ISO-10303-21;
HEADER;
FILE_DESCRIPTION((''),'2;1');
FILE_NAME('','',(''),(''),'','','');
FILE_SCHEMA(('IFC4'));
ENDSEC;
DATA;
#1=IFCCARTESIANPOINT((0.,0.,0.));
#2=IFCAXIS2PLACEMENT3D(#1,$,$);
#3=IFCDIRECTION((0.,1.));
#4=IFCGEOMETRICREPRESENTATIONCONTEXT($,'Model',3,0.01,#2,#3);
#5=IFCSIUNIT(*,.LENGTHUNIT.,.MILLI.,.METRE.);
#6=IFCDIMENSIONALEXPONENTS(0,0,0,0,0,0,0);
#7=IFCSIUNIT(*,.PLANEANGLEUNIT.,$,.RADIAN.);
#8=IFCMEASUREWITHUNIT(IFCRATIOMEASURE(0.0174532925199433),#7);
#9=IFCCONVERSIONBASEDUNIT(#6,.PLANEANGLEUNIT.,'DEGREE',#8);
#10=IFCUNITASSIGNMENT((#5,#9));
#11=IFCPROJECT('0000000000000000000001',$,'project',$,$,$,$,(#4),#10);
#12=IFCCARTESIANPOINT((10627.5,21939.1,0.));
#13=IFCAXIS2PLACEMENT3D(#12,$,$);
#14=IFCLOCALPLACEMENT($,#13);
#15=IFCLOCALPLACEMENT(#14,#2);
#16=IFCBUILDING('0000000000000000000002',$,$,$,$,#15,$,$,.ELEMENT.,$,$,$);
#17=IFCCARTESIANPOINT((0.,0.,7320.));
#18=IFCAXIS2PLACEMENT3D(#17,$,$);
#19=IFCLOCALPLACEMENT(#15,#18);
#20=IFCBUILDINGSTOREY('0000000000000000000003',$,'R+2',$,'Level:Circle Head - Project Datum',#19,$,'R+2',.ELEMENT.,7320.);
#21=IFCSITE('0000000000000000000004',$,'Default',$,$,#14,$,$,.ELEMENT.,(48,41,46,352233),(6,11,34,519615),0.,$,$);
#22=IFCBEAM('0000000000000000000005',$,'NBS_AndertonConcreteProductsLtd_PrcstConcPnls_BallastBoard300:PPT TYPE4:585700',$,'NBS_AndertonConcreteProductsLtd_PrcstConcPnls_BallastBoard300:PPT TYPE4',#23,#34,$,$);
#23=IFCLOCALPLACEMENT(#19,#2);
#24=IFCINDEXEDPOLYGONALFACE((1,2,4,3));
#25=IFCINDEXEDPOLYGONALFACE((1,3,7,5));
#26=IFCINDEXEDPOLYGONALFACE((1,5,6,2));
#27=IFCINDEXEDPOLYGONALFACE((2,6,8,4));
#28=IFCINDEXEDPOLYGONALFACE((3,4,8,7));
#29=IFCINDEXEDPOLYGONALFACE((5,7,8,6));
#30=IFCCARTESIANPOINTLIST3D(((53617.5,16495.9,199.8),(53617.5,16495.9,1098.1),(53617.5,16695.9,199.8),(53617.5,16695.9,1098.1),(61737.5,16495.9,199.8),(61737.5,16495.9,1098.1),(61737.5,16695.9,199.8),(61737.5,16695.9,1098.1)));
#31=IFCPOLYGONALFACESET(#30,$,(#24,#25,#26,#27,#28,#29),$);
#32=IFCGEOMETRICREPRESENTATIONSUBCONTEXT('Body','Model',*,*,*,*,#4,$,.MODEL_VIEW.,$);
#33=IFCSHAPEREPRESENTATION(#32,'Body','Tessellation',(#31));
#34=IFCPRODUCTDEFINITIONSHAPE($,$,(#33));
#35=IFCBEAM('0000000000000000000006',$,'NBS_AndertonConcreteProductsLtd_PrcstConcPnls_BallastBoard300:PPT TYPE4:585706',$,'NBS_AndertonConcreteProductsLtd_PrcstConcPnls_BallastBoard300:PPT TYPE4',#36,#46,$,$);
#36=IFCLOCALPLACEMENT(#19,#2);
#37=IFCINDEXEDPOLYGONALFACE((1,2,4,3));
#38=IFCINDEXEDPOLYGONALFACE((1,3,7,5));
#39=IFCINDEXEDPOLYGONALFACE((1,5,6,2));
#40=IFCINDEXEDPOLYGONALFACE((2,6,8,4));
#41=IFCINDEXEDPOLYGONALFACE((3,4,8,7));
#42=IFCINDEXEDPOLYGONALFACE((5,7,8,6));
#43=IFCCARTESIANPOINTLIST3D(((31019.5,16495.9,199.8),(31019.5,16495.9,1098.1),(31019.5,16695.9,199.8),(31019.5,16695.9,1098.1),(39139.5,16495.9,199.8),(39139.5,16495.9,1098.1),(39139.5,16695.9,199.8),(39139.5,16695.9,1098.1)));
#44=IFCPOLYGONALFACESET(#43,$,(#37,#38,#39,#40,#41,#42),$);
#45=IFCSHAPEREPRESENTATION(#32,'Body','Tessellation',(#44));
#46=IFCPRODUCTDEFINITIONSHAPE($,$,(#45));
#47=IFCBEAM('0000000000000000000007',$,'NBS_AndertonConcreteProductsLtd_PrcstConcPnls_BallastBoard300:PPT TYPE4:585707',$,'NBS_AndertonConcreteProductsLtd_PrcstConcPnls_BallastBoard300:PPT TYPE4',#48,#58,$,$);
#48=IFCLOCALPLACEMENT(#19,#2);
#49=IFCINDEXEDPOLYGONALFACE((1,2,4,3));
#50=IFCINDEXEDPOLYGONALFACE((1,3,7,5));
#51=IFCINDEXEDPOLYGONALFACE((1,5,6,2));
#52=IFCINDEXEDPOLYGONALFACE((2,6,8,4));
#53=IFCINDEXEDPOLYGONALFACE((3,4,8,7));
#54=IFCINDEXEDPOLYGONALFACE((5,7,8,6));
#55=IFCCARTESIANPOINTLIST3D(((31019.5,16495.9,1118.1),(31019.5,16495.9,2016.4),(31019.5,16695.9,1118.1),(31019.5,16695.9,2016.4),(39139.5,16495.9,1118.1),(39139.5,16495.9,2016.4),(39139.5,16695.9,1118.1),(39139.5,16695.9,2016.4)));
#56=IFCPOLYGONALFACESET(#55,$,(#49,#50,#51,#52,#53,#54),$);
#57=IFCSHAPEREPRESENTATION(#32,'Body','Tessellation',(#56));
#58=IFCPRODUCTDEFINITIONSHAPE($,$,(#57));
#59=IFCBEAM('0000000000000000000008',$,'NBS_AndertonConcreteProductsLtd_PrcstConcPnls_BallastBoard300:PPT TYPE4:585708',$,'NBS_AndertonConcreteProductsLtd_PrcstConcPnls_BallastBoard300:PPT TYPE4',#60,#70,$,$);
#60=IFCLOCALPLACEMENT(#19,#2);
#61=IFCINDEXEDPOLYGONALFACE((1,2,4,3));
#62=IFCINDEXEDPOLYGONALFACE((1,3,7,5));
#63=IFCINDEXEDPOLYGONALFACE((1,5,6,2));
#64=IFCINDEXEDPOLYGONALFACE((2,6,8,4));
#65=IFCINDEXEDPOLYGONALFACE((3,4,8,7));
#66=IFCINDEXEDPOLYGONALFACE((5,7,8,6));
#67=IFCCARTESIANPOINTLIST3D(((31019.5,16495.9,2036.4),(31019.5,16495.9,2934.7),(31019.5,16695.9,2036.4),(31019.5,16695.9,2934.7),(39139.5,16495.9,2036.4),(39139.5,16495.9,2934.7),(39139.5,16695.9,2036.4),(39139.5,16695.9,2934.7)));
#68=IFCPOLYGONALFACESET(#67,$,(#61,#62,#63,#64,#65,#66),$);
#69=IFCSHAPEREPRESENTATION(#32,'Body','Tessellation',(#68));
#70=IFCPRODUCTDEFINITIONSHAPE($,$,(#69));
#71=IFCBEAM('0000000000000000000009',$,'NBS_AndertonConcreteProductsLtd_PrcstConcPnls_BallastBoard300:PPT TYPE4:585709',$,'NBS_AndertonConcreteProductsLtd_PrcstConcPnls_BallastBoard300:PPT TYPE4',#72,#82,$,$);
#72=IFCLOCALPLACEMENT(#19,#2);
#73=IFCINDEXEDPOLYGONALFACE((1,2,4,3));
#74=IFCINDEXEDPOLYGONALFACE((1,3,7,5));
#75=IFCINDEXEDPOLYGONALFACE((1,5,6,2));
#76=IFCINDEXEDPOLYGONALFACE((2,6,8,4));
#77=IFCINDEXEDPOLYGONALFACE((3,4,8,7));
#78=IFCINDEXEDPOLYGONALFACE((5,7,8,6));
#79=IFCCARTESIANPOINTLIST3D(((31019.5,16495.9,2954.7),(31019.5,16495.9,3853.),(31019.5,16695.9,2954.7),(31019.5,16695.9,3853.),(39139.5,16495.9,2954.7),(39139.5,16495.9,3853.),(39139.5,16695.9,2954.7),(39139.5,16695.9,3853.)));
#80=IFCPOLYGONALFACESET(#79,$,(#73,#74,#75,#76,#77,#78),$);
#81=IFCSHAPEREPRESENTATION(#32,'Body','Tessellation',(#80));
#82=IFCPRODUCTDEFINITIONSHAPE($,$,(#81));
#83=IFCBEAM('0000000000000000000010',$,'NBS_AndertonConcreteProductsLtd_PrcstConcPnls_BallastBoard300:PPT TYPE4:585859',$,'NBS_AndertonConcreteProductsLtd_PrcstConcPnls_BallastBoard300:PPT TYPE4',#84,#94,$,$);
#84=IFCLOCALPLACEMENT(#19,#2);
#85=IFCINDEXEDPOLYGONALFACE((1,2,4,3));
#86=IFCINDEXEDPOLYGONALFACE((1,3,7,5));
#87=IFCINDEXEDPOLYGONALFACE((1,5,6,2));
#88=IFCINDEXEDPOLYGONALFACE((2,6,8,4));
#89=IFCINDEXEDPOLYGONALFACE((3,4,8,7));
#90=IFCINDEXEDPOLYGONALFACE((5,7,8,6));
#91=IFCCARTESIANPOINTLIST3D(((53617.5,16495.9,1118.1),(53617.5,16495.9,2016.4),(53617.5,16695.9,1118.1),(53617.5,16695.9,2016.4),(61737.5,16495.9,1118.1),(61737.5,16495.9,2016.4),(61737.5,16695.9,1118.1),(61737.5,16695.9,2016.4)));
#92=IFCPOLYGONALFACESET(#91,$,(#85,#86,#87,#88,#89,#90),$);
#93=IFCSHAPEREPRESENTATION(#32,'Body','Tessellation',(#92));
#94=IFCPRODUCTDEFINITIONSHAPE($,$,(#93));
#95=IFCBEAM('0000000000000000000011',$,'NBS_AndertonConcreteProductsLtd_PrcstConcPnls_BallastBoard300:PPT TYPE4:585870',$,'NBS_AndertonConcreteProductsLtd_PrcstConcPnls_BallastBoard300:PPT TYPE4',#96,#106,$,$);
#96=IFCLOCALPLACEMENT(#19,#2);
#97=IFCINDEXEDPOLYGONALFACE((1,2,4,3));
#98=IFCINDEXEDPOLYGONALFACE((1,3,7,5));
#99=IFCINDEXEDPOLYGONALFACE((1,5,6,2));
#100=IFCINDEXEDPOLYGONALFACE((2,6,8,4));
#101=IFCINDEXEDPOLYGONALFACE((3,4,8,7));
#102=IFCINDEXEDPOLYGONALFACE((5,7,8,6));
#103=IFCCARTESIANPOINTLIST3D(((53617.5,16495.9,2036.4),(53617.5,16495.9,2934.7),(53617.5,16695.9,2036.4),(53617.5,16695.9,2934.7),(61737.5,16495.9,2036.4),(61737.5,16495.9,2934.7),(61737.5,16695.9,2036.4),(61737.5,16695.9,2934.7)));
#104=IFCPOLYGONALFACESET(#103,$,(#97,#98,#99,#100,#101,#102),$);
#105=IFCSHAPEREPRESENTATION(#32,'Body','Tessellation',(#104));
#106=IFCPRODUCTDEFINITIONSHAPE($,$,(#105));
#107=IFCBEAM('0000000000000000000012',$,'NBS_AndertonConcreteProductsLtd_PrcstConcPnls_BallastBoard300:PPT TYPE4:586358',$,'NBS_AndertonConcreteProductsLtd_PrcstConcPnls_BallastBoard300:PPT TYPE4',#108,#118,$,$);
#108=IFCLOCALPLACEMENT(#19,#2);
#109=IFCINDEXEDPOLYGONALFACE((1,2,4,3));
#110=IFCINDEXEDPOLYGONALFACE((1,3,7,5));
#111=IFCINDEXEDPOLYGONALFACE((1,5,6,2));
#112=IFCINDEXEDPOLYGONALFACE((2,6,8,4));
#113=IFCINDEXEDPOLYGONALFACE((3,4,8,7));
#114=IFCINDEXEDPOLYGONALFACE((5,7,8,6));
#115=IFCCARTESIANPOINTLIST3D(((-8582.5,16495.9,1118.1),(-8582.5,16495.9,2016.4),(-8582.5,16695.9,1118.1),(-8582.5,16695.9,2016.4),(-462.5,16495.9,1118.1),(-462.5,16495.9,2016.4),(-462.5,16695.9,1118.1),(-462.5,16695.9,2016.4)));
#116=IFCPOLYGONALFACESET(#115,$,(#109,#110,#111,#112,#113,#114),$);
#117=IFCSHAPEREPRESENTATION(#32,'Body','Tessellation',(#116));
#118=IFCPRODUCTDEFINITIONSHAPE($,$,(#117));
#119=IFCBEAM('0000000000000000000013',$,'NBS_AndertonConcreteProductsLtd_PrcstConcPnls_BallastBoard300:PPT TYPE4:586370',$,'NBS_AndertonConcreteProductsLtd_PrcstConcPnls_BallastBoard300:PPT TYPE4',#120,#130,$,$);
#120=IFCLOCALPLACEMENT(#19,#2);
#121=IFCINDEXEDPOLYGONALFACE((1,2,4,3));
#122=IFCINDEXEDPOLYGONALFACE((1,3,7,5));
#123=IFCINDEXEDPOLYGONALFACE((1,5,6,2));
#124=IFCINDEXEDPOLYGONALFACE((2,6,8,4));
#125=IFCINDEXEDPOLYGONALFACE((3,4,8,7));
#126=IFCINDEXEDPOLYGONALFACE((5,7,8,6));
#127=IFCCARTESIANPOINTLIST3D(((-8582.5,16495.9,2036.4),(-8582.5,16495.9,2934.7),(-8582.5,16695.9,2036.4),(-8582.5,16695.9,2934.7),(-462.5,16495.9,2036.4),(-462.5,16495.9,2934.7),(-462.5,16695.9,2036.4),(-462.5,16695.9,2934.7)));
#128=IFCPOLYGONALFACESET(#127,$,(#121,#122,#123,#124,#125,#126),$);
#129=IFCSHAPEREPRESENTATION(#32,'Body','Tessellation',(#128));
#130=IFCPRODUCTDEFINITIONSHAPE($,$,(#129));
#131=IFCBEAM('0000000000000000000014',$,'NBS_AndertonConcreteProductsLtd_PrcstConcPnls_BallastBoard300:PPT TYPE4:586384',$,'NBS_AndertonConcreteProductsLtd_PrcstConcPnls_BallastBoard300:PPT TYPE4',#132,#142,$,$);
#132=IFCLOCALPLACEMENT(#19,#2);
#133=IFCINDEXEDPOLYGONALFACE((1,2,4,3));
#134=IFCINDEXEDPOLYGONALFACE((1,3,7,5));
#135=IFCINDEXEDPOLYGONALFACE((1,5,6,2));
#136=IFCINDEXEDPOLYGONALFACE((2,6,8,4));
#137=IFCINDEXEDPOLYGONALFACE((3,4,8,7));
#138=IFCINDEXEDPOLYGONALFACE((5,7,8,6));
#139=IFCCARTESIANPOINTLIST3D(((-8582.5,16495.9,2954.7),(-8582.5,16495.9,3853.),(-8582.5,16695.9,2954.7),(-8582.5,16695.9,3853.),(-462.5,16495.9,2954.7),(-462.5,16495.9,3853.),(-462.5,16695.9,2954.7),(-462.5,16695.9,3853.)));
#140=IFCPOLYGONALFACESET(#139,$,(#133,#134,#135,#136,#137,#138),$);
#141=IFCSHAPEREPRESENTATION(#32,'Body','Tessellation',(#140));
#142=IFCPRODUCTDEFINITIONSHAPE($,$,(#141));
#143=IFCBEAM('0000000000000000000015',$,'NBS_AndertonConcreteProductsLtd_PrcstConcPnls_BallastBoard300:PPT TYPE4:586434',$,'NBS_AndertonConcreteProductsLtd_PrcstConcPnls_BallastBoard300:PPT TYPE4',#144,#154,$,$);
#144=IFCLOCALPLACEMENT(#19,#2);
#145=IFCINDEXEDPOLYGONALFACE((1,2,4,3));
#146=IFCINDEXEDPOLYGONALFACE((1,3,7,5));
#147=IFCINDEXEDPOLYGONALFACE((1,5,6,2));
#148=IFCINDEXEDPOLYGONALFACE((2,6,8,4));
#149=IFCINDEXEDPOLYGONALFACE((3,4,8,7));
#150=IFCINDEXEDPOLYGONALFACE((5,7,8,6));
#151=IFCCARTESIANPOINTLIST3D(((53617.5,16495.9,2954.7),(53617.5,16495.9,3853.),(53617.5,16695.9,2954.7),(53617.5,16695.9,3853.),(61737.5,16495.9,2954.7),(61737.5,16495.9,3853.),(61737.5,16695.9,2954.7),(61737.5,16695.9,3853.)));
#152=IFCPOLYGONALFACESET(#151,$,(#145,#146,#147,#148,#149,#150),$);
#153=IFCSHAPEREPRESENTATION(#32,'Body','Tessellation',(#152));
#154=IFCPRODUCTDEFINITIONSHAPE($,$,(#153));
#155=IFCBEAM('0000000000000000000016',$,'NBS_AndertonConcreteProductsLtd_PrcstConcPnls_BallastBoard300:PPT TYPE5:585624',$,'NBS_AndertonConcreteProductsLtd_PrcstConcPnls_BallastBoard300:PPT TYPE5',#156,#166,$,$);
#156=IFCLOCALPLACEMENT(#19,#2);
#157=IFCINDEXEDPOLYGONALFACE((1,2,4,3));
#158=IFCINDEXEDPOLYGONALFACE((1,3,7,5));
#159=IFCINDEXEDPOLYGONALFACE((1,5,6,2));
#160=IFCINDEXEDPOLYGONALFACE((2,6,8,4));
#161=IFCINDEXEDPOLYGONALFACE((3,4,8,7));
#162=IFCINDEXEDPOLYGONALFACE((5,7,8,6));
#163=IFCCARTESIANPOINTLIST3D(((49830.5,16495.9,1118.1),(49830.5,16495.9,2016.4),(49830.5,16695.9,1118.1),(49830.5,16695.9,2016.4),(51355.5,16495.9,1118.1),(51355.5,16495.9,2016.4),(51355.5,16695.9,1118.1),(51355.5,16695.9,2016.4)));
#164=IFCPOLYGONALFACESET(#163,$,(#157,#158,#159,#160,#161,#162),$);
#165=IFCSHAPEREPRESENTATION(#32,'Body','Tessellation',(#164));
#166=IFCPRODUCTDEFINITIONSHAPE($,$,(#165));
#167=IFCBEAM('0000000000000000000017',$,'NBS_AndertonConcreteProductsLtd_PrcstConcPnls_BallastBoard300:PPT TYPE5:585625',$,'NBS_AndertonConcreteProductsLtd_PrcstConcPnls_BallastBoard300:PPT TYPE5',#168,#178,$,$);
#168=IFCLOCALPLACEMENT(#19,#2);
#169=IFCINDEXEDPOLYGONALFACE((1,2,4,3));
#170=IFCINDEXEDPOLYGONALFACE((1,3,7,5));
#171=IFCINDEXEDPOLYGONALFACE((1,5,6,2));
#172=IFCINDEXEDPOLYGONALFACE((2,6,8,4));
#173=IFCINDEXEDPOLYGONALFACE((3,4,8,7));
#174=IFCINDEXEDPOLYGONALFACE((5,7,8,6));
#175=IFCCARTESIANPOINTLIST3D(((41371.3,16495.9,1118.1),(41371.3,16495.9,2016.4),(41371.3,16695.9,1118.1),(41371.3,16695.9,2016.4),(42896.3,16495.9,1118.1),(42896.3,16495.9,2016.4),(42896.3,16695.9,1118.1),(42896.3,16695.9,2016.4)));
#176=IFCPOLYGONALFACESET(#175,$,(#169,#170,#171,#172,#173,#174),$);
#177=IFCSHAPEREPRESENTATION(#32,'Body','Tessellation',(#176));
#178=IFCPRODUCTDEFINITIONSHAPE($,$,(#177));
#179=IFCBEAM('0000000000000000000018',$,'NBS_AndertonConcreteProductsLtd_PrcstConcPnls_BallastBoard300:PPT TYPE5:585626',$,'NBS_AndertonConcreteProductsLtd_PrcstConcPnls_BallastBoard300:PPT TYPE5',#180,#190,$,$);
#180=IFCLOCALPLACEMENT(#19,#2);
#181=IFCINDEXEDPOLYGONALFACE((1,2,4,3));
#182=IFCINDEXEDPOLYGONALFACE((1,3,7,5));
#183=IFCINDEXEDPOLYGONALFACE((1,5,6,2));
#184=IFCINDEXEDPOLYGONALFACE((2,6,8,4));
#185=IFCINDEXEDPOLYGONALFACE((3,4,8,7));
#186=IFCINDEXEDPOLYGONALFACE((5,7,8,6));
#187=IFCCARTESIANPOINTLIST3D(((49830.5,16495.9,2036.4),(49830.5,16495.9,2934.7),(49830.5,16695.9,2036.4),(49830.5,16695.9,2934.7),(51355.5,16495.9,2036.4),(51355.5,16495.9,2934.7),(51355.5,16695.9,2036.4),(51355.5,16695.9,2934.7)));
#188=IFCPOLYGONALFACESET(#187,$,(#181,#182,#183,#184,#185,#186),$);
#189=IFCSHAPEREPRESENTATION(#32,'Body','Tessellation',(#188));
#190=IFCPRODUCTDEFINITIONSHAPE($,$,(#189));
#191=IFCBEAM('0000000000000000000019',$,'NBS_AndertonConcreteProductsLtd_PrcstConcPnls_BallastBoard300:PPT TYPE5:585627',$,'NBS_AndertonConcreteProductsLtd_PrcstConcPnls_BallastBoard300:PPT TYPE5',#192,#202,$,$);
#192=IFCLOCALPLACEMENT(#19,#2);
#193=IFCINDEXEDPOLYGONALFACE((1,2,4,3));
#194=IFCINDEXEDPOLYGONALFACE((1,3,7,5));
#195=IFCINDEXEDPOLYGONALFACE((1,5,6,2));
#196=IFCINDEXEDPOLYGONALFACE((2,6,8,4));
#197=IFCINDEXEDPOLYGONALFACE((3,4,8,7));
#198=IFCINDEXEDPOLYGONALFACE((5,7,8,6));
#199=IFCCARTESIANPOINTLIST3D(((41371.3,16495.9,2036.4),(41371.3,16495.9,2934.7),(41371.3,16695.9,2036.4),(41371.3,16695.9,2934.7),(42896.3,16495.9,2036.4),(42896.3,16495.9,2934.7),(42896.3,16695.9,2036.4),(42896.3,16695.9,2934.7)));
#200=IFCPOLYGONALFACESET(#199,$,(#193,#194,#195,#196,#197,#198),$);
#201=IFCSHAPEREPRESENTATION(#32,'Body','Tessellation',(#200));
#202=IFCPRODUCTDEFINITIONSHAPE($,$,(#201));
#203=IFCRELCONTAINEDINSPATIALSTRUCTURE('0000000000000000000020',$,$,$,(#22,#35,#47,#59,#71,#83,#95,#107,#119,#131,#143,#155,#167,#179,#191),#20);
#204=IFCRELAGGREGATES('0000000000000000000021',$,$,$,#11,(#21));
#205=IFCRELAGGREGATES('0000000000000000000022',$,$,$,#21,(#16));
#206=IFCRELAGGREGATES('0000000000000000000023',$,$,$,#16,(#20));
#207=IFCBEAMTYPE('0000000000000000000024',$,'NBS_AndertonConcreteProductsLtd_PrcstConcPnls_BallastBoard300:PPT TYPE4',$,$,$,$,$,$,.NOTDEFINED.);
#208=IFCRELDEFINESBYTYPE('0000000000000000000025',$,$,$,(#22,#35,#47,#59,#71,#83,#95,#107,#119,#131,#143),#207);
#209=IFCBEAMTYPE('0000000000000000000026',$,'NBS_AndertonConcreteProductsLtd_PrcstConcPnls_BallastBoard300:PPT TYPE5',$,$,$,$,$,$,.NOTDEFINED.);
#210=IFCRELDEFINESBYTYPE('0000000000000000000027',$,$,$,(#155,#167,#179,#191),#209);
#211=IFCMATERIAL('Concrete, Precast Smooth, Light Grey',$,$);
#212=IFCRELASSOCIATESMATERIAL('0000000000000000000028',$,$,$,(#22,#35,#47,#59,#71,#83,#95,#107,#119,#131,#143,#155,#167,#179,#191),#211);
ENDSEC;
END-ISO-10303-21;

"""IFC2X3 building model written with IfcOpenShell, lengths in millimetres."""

from ifc_helpers import new_model, entity, si_unit, converted_unit, direction, frame, frame_2d, origin, place, context, subcontext, project, spatial, rectangle, extrude, material, type_object, element, save


model = new_model("IFC2X3")

# Units and contexts
model_context = context("Model", 3, precision=0.01, world=origin(), true_north=direction((0.0, 1.0)))
body_context = subcontext(model_context, "Body", "Model", "MODEL_VIEW")
ifc_project = project(units=[si_unit("LENGTHUNIT", "METRE", prefix="MILLI"), converted_unit("PLANEANGLEUNIT", "DEGREE", entity("IfcRatioMeasure", 0.0174532925199433), si_unit("PLANEANGLEUNIT", "RADIAN"), dimensions=[0, 0, 0, 0, 0, 0, 0])], contexts=[model_context])

# Site, building, storey
site_placement = place(None, frame((10627.5, 21939.1, 0.0)))
site = spatial("IfcSite", under=ifc_project, at=site_placement, Name="Default", CompositionType="ELEMENT", RefLatitude=(48, 41, 46, 352233), RefLongitude=(6, 11, 34, 519615), RefElevation=0.0)
building_placement = place(site_placement, origin())
building = spatial("IfcBuilding", under=site, at=building_placement, CompositionType="ELEMENT")
storey_placement = place(building_placement, frame((0.0, 0.0, 7320.0)))
storey = spatial("IfcBuildingStorey", under=building, at=storey_placement, Name="R+2", ObjectType="Level:Circle Head - Project Datum", LongName="R+2", CompositionType="ELEMENT", Elevation=7320.0)

# Beams
ifc_material_1 = material(Name="Concrete, Precast Smooth, Light Grey")
beam_type_1 = type_object("IfcBeamType", Name="NBS_AndertonConcreteProductsLtd_PrcstConcPnls_BallastBoard300:PPT TYPE4", PredefinedType="NOTDEFINED")
beam_1_placement = place(storey_placement, origin())
element("IfcBeam", 1, at=beam_1_placement, inside=storey, type_object=beam_type_1, material=ifc_material_1, Name="NBS_AndertonConcreteProductsLtd_PrcstConcPnls_BallastBoard300:PPT TYPE4:585700", ObjectType="NBS_AndertonConcreteProductsLtd_PrcstConcPnls_BallastBoard300:PPT TYPE4", context=body_context, shape_type="SweptSolid", body=[
    extrude(rectangle(XDim=898.3, YDim=200.0, at=frame_2d((0.0, 0.0), x_axis=(1.0, 0.0))), frame((53617.5, 16595.9, 649.0), z_axis=(1.0, 0.0, 0.0), x_axis=(0.0, 0.0, -1.0)), (0.0, 0.0, 1.0), 8120.0),
])
beam_2_placement = place(storey_placement, origin())
element("IfcBeam", 2, at=beam_2_placement, inside=storey, type_object=beam_type_1, material=ifc_material_1, Name="NBS_AndertonConcreteProductsLtd_PrcstConcPnls_BallastBoard300:PPT TYPE4:585706", ObjectType="NBS_AndertonConcreteProductsLtd_PrcstConcPnls_BallastBoard300:PPT TYPE4", context=body_context, shape_type="SweptSolid", body=[
    extrude(rectangle(XDim=898.3, YDim=200.0, at=frame_2d((0.0, 0.0), x_axis=(1.0, 0.0))), frame((31019.5, 16595.9, 649.0), z_axis=(1.0, 0.0, 0.0), x_axis=(0.0, 0.0, -1.0)), (0.0, 0.0, 1.0), 8120.0),
])
beam_3_placement = place(storey_placement, origin())
element("IfcBeam", 3, at=beam_3_placement, inside=storey, type_object=beam_type_1, material=ifc_material_1, Name="NBS_AndertonConcreteProductsLtd_PrcstConcPnls_BallastBoard300:PPT TYPE4:585707", ObjectType="NBS_AndertonConcreteProductsLtd_PrcstConcPnls_BallastBoard300:PPT TYPE4", context=body_context, shape_type="SweptSolid", body=[
    extrude(rectangle(XDim=898.3, YDim=200.0, at=frame_2d((0.0, 0.0), x_axis=(1.0, 0.0))), frame((31019.5, 16595.9, 1567.3), z_axis=(1.0, 0.0, 0.0), x_axis=(0.0, 0.0, -1.0)), (0.0, 0.0, 1.0), 8120.0),
])
beam_4_placement = place(storey_placement, origin())
element("IfcBeam", 4, at=beam_4_placement, inside=storey, type_object=beam_type_1, material=ifc_material_1, Name="NBS_AndertonConcreteProductsLtd_PrcstConcPnls_BallastBoard300:PPT TYPE4:585708", ObjectType="NBS_AndertonConcreteProductsLtd_PrcstConcPnls_BallastBoard300:PPT TYPE4", context=body_context, shape_type="SweptSolid", body=[
    extrude(rectangle(XDim=898.3, YDim=200.0, at=frame_2d((0.0, 0.0), x_axis=(1.0, 0.0))), frame((31019.5, 16595.9, 2485.6), z_axis=(1.0, 0.0, 0.0), x_axis=(0.0, 0.0, -1.0)), (0.0, 0.0, 1.0), 8120.0),
])
beam_5_placement = place(storey_placement, origin())
element("IfcBeam", 5, at=beam_5_placement, inside=storey, type_object=beam_type_1, material=ifc_material_1, Name="NBS_AndertonConcreteProductsLtd_PrcstConcPnls_BallastBoard300:PPT TYPE4:585709", ObjectType="NBS_AndertonConcreteProductsLtd_PrcstConcPnls_BallastBoard300:PPT TYPE4", context=body_context, shape_type="SweptSolid", body=[
    extrude(rectangle(XDim=898.3, YDim=200.0, at=frame_2d((0.0, 0.0), x_axis=(1.0, 0.0))), frame((31019.5, 16595.9, 3403.9), z_axis=(1.0, 0.0, 0.0), x_axis=(0.0, 0.0, -1.0)), (0.0, 0.0, 1.0), 8120.0),
])
beam_6_placement = place(storey_placement, origin())
element("IfcBeam", 6, at=beam_6_placement, inside=storey, type_object=beam_type_1, material=ifc_material_1, Name="NBS_AndertonConcreteProductsLtd_PrcstConcPnls_BallastBoard300:PPT TYPE4:585859", ObjectType="NBS_AndertonConcreteProductsLtd_PrcstConcPnls_BallastBoard300:PPT TYPE4", context=body_context, shape_type="SweptSolid", body=[
    extrude(rectangle(XDim=898.3, YDim=200.0, at=frame_2d((0.0, 0.0), x_axis=(1.0, 0.0))), frame((53617.5, 16595.9, 1567.3), z_axis=(1.0, 0.0, 0.0), x_axis=(0.0, 0.0, -1.0)), (0.0, 0.0, 1.0), 8120.0),
])
beam_7_placement = place(storey_placement, origin())
element("IfcBeam", 7, at=beam_7_placement, inside=storey, type_object=beam_type_1, material=ifc_material_1, Name="NBS_AndertonConcreteProductsLtd_PrcstConcPnls_BallastBoard300:PPT TYPE4:585870", ObjectType="NBS_AndertonConcreteProductsLtd_PrcstConcPnls_BallastBoard300:PPT TYPE4", context=body_context, shape_type="SweptSolid", body=[
    extrude(rectangle(XDim=898.3, YDim=200.0, at=frame_2d((0.0, 0.0), x_axis=(1.0, 0.0))), frame((53617.5, 16595.9, 2485.6), z_axis=(1.0, 0.0, 0.0), x_axis=(0.0, 0.0, -1.0)), (0.0, 0.0, 1.0), 8120.0),
])
beam_8_placement = place(storey_placement, origin())
element("IfcBeam", 8, at=beam_8_placement, inside=storey, type_object=beam_type_1, material=ifc_material_1, Name="NBS_AndertonConcreteProductsLtd_PrcstConcPnls_BallastBoard300:PPT TYPE4:586358", ObjectType="NBS_AndertonConcreteProductsLtd_PrcstConcPnls_BallastBoard300:PPT TYPE4", context=body_context, shape_type="SweptSolid", body=[
    extrude(rectangle(XDim=898.3, YDim=200.0, at=frame_2d((0.0, 0.0), x_axis=(0.0, 1.0))), frame((-8582.5, 16595.9, 1567.3), z_axis=(1.0, 0.0, 0.0), x_axis=(0.0, 1.0, 0.0)), (0.0, 0.0, 1.0), 8120.0),
])
beam_9_placement = place(storey_placement, origin())
element("IfcBeam", 9, at=beam_9_placement, inside=storey, type_object=beam_type_1, material=ifc_material_1, Name="NBS_AndertonConcreteProductsLtd_PrcstConcPnls_BallastBoard300:PPT TYPE4:586370", ObjectType="NBS_AndertonConcreteProductsLtd_PrcstConcPnls_BallastBoard300:PPT TYPE4", context=body_context, shape_type="SweptSolid", body=[
    extrude(rectangle(XDim=898.3, YDim=200.0, at=frame_2d((0.0, 0.0), x_axis=(0.0, 1.0))), frame((-8582.5, 16595.9, 2485.6), z_axis=(1.0, 0.0, 0.0), x_axis=(0.0, 1.0, 0.0)), (0.0, 0.0, 1.0), 8120.0),
])
beam_10_placement = place(storey_placement, origin())
element("IfcBeam", 10, at=beam_10_placement, inside=storey, type_object=beam_type_1, material=ifc_material_1, Name="NBS_AndertonConcreteProductsLtd_PrcstConcPnls_BallastBoard300:PPT TYPE4:586384", ObjectType="NBS_AndertonConcreteProductsLtd_PrcstConcPnls_BallastBoard300:PPT TYPE4", context=body_context, shape_type="SweptSolid", body=[
    extrude(rectangle(XDim=898.3, YDim=200.0, at=frame_2d((0.0, 0.0), x_axis=(0.0, 1.0))), frame((-8582.5, 16595.9, 3403.9), z_axis=(1.0, 0.0, 0.0), x_axis=(0.0, 1.0, 0.0)), (0.0, 0.0, 1.0), 8120.0),
])
beam_11_placement = place(storey_placement, origin())
element("IfcBeam", 11, at=beam_11_placement, inside=storey, type_object=beam_type_1, material=ifc_material_1, Name="NBS_AndertonConcreteProductsLtd_PrcstConcPnls_BallastBoard300:PPT TYPE4:586434", ObjectType="NBS_AndertonConcreteProductsLtd_PrcstConcPnls_BallastBoard300:PPT TYPE4", context=body_context, shape_type="SweptSolid", body=[
    extrude(rectangle(XDim=898.3, YDim=200.0, at=frame_2d((0.0, 0.0), x_axis=(1.0, 0.0))), frame((53617.5, 16595.9, 3403.9), z_axis=(1.0, 0.0, 0.0), x_axis=(0.0, 0.0, -1.0)), (0.0, 0.0, 1.0), 8120.0),
])
beam_type_2 = type_object("IfcBeamType", Name="NBS_AndertonConcreteProductsLtd_PrcstConcPnls_BallastBoard300:PPT TYPE5", PredefinedType="NOTDEFINED")
beam_12_placement = place(storey_placement, origin())
element("IfcBeam", 12, at=beam_12_placement, inside=storey, type_object=beam_type_2, material=ifc_material_1, Name="NBS_AndertonConcreteProductsLtd_PrcstConcPnls_BallastBoard300:PPT TYPE5:585624", ObjectType="NBS_AndertonConcreteProductsLtd_PrcstConcPnls_BallastBoard300:PPT TYPE5", context=body_context, shape_type="SweptSolid", body=[
    extrude(rectangle(XDim=898.3, YDim=200.0, at=frame_2d((0.0, 0.0), x_axis=(1.0, 0.0))), frame((49830.5, 16595.9, 1567.3), z_axis=(1.0, 0.0, 0.0), x_axis=(0.0, 0.0, -1.0)), (0.0, 0.0, 1.0), 1525.0),
])
beam_13_placement = place(storey_placement, origin())
element("IfcBeam", 13, at=beam_13_placement, inside=storey, type_object=beam_type_2, material=ifc_material_1, Name="NBS_AndertonConcreteProductsLtd_PrcstConcPnls_BallastBoard300:PPT TYPE5:585625", ObjectType="NBS_AndertonConcreteProductsLtd_PrcstConcPnls_BallastBoard300:PPT TYPE5", context=body_context, shape_type="SweptSolid", body=[
    extrude(rectangle(XDim=898.3, YDim=200.0, at=frame_2d((0.0, 0.0), x_axis=(1.0, 0.0))), frame((41371.3, 16595.9, 1567.3), z_axis=(1.0, 0.0, 0.0), x_axis=(0.0, 0.0, -1.0)), (0.0, 0.0, 1.0), 1525.0),
])
beam_14_placement = place(storey_placement, origin())
element("IfcBeam", 14, at=beam_14_placement, inside=storey, type_object=beam_type_2, material=ifc_material_1, Name="NBS_AndertonConcreteProductsLtd_PrcstConcPnls_BallastBoard300:PPT TYPE5:585626", ObjectType="NBS_AndertonConcreteProductsLtd_PrcstConcPnls_BallastBoard300:PPT TYPE5", context=body_context, shape_type="SweptSolid", body=[
    extrude(rectangle(XDim=898.3, YDim=200.0, at=frame_2d((0.0, 0.0), x_axis=(1.0, 0.0))), frame((49830.5, 16595.9, 2485.6), z_axis=(1.0, 0.0, 0.0), x_axis=(0.0, 0.0, -1.0)), (0.0, 0.0, 1.0), 1525.0),
])
beam_15_placement = place(storey_placement, origin())
element("IfcBeam", 15, at=beam_15_placement, inside=storey, type_object=beam_type_2, material=ifc_material_1, Name="NBS_AndertonConcreteProductsLtd_PrcstConcPnls_BallastBoard300:PPT TYPE5:585627", ObjectType="NBS_AndertonConcreteProductsLtd_PrcstConcPnls_BallastBoard300:PPT TYPE5", context=body_context, shape_type="SweptSolid", body=[
    extrude(rectangle(XDim=898.3, YDim=200.0, at=frame_2d((0.0, 0.0), x_axis=(1.0, 0.0))), frame((41371.3, 16595.9, 2485.6), z_axis=(1.0, 0.0, 0.0), x_axis=(0.0, 0.0, -1.0)), (0.0, 0.0, 1.0), 1525.0),
])

save(model, "model.ifc")
